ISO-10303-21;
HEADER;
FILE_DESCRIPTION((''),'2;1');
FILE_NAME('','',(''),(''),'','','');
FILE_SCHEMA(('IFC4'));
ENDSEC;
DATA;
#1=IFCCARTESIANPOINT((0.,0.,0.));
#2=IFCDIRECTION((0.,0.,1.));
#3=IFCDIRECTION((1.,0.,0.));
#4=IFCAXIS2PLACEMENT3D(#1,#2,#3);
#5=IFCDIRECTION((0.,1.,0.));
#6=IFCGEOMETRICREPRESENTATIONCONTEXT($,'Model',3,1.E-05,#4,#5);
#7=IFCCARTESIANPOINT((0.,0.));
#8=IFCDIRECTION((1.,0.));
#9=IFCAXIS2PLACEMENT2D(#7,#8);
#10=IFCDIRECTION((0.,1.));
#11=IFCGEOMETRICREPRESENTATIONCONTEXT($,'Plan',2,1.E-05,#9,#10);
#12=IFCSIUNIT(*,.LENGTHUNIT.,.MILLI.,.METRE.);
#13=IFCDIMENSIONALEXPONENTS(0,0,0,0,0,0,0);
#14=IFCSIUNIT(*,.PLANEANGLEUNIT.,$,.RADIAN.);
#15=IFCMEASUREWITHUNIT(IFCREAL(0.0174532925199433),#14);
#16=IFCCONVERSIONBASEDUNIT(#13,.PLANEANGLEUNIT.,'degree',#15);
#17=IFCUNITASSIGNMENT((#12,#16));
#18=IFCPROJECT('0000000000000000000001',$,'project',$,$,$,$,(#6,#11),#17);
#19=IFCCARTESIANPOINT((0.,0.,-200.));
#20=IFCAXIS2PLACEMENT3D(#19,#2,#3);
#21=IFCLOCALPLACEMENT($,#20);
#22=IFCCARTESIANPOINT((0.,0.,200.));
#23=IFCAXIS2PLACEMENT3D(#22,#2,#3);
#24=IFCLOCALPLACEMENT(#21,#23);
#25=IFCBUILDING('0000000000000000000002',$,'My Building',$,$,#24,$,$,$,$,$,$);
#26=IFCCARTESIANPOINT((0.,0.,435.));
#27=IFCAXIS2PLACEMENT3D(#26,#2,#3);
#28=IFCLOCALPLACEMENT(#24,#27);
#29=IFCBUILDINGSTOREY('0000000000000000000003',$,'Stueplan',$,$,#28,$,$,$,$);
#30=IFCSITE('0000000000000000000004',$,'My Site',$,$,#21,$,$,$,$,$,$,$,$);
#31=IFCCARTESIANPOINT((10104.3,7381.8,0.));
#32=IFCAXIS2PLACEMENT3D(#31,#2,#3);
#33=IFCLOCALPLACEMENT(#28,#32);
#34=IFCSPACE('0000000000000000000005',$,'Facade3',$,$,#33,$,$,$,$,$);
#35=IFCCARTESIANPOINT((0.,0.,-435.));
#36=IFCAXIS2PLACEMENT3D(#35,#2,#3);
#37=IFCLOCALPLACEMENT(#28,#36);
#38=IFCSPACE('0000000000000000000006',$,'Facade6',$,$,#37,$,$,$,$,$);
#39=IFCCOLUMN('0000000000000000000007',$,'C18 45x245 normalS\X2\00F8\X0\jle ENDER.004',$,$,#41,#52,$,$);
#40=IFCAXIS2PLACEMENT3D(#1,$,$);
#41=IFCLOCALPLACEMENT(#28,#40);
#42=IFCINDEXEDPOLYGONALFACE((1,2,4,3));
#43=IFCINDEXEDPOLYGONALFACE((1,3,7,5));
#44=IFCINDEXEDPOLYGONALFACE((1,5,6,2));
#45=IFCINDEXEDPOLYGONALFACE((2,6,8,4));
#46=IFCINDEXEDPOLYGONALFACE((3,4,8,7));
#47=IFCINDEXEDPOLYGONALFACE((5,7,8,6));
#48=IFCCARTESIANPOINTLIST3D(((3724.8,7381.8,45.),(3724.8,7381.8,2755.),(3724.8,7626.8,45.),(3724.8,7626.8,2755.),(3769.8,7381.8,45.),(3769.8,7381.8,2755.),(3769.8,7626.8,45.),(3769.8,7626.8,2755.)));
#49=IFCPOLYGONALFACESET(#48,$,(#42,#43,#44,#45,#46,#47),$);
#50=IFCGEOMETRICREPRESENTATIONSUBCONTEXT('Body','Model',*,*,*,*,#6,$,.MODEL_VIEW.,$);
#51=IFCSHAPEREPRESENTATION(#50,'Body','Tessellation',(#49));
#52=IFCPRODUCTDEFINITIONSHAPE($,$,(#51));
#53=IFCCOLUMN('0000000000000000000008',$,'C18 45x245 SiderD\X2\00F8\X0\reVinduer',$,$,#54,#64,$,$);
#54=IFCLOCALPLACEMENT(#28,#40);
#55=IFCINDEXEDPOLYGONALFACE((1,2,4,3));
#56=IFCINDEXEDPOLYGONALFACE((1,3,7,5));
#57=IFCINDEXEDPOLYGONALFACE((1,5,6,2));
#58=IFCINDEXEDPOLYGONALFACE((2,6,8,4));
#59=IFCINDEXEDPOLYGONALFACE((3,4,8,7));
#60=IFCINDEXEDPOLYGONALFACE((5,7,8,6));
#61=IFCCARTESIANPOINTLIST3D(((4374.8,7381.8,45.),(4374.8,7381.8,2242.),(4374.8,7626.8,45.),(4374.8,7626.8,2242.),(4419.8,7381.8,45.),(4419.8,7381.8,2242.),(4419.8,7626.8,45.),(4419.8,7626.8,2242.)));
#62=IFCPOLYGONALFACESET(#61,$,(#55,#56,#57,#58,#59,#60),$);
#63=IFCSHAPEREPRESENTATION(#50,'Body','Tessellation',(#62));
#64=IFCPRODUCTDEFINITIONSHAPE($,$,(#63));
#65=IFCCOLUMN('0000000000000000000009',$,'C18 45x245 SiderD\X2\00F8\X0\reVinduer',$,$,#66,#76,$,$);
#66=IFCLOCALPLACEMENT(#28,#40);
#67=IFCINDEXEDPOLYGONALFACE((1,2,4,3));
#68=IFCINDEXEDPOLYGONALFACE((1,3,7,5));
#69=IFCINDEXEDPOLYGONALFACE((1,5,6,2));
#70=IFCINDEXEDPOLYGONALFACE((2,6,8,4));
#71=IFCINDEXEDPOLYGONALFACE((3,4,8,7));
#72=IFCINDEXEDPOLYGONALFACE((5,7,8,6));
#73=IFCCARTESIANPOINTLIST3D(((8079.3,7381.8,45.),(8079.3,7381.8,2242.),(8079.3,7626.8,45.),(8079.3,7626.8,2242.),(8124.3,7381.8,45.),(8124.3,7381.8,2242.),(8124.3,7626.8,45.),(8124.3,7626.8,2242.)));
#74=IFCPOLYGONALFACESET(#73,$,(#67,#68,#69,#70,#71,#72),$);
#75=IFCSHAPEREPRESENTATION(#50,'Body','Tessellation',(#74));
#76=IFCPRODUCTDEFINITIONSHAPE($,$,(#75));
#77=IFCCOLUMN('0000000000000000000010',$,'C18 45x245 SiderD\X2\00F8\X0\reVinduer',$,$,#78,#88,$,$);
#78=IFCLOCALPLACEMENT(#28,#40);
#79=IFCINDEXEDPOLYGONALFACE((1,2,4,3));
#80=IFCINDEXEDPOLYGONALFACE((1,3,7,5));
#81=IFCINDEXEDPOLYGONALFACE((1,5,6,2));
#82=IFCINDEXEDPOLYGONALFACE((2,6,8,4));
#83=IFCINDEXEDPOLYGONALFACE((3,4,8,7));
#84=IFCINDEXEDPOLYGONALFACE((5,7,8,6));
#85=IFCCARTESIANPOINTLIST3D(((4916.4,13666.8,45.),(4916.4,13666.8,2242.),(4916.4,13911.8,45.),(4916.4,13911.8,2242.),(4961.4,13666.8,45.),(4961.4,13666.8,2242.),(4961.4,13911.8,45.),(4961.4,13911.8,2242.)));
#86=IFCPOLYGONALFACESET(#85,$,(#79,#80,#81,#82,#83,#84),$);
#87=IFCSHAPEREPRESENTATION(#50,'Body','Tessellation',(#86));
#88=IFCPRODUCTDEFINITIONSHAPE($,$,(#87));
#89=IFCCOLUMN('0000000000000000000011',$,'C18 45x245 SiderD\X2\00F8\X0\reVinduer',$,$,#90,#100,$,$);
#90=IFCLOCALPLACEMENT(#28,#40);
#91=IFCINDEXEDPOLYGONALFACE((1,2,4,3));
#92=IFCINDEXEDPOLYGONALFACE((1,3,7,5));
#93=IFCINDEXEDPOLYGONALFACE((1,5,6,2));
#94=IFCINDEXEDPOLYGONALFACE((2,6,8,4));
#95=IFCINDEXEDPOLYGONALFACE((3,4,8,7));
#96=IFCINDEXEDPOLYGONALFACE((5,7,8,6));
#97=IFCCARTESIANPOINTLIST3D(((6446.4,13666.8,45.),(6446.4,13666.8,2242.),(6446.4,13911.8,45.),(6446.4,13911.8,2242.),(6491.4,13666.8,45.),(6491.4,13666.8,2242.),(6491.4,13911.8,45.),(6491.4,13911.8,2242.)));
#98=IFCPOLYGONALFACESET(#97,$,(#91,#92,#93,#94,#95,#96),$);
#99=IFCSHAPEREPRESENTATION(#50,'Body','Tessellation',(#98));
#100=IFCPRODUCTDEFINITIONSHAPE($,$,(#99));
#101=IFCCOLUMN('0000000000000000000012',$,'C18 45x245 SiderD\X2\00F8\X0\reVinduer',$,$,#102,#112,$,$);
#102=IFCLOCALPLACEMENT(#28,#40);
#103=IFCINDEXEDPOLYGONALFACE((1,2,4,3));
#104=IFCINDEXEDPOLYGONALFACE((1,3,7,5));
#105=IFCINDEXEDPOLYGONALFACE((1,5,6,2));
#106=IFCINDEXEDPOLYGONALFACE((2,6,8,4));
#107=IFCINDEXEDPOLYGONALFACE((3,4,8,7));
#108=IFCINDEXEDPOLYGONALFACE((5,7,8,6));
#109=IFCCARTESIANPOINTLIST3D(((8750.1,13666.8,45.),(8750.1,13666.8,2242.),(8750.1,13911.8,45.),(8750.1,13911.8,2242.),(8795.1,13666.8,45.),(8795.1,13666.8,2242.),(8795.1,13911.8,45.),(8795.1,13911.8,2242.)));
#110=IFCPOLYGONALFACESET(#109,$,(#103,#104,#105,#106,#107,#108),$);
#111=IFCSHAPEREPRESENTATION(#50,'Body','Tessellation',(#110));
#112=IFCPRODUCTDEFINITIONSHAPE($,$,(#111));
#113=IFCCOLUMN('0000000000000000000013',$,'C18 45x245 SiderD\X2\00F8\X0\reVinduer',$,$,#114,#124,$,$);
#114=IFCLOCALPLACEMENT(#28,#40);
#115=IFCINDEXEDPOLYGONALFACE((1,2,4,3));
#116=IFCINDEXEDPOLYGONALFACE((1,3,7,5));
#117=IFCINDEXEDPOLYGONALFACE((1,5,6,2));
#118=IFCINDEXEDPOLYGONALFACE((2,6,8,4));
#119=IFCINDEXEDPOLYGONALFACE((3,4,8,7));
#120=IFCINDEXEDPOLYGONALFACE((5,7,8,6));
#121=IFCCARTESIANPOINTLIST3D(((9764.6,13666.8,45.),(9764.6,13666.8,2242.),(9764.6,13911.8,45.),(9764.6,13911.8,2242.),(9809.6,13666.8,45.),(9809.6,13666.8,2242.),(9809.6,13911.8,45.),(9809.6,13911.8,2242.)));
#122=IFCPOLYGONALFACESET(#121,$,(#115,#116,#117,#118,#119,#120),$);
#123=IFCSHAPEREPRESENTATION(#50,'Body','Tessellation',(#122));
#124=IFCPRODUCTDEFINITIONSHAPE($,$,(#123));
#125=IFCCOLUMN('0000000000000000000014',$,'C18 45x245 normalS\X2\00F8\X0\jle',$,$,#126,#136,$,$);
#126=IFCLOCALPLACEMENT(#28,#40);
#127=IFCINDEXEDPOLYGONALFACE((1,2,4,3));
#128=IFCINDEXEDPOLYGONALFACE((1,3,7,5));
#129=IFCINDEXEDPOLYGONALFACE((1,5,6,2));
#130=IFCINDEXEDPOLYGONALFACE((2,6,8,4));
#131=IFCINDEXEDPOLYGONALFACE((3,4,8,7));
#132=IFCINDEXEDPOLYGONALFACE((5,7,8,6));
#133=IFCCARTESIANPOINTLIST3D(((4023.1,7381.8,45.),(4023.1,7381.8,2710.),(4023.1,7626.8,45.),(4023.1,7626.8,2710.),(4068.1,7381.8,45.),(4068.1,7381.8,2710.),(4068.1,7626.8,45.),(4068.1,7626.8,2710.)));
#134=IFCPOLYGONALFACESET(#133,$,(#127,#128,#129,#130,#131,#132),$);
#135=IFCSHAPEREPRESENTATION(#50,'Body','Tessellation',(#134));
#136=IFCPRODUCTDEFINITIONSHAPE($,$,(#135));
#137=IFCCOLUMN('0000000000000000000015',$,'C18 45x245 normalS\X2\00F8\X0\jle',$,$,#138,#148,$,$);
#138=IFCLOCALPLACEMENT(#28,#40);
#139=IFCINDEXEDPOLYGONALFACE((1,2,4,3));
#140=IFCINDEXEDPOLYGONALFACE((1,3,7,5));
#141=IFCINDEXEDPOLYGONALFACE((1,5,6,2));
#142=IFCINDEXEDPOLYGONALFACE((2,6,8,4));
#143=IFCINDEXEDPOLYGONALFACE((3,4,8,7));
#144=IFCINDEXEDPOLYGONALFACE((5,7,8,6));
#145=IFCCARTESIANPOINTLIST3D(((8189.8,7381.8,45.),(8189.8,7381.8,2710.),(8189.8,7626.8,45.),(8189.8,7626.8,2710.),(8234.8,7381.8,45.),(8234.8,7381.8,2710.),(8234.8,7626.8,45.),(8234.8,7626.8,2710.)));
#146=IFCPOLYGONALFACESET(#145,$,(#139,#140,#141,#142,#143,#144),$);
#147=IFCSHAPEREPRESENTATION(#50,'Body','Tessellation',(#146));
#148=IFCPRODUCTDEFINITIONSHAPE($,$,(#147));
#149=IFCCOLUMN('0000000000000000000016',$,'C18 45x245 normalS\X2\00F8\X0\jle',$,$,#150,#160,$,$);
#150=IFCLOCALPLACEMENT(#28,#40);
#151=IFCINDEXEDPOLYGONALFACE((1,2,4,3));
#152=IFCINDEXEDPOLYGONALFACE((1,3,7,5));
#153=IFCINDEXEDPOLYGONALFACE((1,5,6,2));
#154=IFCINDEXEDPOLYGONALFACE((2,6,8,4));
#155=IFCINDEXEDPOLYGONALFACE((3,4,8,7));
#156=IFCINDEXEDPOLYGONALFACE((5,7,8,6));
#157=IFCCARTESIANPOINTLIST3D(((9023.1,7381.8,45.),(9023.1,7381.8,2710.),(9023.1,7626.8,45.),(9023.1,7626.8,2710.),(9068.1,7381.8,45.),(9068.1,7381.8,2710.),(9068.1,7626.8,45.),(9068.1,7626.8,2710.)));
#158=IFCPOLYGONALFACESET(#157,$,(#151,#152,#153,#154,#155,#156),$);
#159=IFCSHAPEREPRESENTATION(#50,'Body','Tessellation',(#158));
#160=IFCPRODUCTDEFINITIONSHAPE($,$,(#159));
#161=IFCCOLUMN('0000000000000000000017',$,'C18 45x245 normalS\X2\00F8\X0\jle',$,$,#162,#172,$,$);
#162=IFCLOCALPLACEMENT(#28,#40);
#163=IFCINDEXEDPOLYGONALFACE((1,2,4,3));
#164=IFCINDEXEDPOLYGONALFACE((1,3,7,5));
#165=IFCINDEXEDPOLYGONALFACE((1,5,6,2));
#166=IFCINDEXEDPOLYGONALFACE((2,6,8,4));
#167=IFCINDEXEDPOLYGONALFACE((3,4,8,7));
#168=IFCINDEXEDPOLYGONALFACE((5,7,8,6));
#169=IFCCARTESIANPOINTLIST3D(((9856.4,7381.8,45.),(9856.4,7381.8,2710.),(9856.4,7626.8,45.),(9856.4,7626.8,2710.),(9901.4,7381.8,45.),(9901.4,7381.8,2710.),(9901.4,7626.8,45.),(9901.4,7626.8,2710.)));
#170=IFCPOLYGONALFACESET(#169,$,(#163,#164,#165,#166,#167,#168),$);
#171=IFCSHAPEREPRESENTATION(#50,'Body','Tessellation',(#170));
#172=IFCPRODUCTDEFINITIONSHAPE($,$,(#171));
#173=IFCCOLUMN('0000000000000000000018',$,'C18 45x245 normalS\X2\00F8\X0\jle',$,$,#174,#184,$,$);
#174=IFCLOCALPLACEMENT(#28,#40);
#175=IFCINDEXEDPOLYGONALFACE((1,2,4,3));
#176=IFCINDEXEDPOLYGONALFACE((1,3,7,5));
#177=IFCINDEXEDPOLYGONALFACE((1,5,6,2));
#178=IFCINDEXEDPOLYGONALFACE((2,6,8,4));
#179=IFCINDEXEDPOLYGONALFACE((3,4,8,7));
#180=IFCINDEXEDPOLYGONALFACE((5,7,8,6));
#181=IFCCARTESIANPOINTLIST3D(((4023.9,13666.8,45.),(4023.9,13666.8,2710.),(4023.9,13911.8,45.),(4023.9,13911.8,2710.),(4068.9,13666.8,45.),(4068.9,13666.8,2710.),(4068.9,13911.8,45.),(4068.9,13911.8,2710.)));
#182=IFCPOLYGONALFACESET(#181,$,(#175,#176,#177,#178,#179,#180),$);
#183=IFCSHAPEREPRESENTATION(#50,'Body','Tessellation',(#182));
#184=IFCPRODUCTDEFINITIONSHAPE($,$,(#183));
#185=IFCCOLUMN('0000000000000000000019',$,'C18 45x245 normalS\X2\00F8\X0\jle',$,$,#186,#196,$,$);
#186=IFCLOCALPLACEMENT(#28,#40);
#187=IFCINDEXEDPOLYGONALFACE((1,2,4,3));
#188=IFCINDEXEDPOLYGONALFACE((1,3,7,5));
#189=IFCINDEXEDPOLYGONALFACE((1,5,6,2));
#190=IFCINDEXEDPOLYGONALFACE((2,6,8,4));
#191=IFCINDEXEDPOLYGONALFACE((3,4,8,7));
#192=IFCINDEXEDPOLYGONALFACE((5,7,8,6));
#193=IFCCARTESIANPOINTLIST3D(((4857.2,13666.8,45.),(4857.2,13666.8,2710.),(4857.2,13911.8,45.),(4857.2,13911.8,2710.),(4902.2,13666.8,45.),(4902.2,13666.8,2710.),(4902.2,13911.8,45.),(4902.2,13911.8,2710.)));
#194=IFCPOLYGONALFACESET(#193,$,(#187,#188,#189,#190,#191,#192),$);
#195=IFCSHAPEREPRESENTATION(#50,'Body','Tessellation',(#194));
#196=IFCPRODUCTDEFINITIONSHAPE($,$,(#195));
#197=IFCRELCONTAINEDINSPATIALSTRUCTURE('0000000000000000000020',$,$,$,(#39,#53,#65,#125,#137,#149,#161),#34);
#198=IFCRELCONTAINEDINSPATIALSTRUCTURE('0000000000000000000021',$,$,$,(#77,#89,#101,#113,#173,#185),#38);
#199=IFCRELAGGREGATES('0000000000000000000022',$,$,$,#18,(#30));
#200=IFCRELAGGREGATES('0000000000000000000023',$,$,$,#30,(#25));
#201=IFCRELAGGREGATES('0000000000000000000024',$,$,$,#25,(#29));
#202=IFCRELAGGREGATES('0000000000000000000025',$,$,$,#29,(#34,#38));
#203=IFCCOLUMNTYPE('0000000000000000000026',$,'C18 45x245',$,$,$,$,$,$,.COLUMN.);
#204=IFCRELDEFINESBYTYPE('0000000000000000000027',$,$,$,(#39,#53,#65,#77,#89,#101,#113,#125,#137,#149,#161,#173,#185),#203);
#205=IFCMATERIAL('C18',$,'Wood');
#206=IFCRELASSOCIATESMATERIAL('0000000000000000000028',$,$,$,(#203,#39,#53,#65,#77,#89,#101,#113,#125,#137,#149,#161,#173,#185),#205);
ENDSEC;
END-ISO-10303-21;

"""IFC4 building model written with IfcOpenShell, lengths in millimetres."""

from ifc_helpers import new_model, entity, si_unit, converted_unit, direction, frame, origin_with_axes, origin_2d_with_axis, place, context, subcontext, project, spatial, rectangle, extrude, material, material_profile, profile_set, profile_usage, type_object, element, save


model = new_model("IFC4")

# Units and contexts
model_context = context("Model", 3, precision=1e-05, world=origin_with_axes(), true_north=direction((0.0, 1.0, 0.0)))
plan_context = context("Plan", 2, precision=1e-05, world=origin_2d_with_axis(), true_north=direction((0.0, 1.0)))
body_context_1 = subcontext(model_context, "Body", "Model", "MODEL_VIEW")
ifc_project = project(units=[si_unit("LENGTHUNIT", "METRE", prefix="MILLI"), converted_unit("PLANEANGLEUNIT", "degree", entity("IfcReal", 0.0174532925199433), si_unit("PLANEANGLEUNIT", "RADIAN"), dimensions=[0, 0, 0, 0, 0, 0, 0])], contexts=[model_context, plan_context])

# Site, building, storey, space
site_placement = place(None, frame((0.0, 0.0, -200.0), z_axis=(0.0, 0.0, 1.0), x_axis=(1.0, 0.0, 0.0)))
site = spatial("IfcSite", under=ifc_project, at=site_placement, Name="My Site")
building_placement = place(site_placement, frame((0.0, 0.0, 200.0), z_axis=(0.0, 0.0, 1.0), x_axis=(1.0, 0.0, 0.0)))
building = spatial("IfcBuilding", under=site, at=building_placement, Name="My Building")
storey_placement = place(building_placement, frame((0.0, 0.0, 435.0), z_axis=(0.0, 0.0, 1.0), x_axis=(1.0, 0.0, 0.0)))
storey = spatial("IfcBuildingStorey", under=building, at=storey_placement, Name="Stueplan")
space_1_placement = place(storey_placement, frame((10104.3, 7381.8, 0.0), z_axis=(0.0, 0.0, 1.0), x_axis=(1.0, 0.0, 0.0)))
space_1 = spatial("IfcSpace", under=storey, at=space_1_placement, Name="Facade3")

# Columns
ifc_material = material(Name="C18", Category="Wood")
ifc_material_profile_1 = material_profile(ifc_material, rectangle(XDim=45.0, YDim=245.0))
ifc_profile_set_1 = profile_set([ifc_material_profile_1], Name="woodStructural")
ifc_profile_usage_1 = profile_usage(ifc_profile_set_1, cardinal=9)
column_type = type_object("IfcColumnType", Name="C18 45x245", PredefinedType="COLUMN", material=ifc_profile_set_1)
column_1_placement = place(space_1_placement, frame((-6379.6, 245.0, 45.0), z_axis=(0.0, 0.0, 1.0), x_axis=(1.0, 0.0, 0.0)))
element("IfcColumn", 1, at=column_1_placement, inside=space_1, type_object=column_type, material=ifc_profile_usage_1, Name="C18 45x245 normalSøjle ENDER.004", context=body_context_1, shape_type="SweptSolid", body=[
    extrude(rectangle(XDim=45.0, YDim=245.0), frame((22.5, -122.5, 0.0), z_axis=(0.0, 0.0, 1.0), x_axis=(1.0, 0.0, 0.0)), (0.0, 0.0, 1.0), 2710.0),
])
ifc_profile_usage_2 = profile_usage(ifc_profile_set_1, cardinal=9)
column_2_placement = place(space_1_placement, frame((-5729.6, 245.0, 45.0), z_axis=(0.0, 0.0, 1.0), x_axis=(1.0, 0.0, 0.0)))
element("IfcColumn", 2, at=column_2_placement, inside=space_1, type_object=column_type, material=ifc_profile_usage_2, Name="C18 45x245 SiderDøreVinduer", context=body_context_1, shape_type="SweptSolid", body=[
    extrude(rectangle(XDim=45.0, YDim=245.0), frame((22.5, -122.5, 0.0), z_axis=(0.0, 0.0, 1.0), x_axis=(1.0, 0.0, 0.0)), (0.0, 0.0, 1.0), 2197.0),
])
ifc_profile_usage_3 = profile_usage(ifc_profile_set_1, cardinal=9)
column_3_placement = place(space_1_placement, frame((-2025.0, 245.0, 45.0), z_axis=(0.0, 0.0, 1.0), x_axis=(1.0, 0.0, 0.0)))
element("IfcColumn", 3, at=column_3_placement, inside=space_1, type_object=column_type, material=ifc_profile_usage_3, Name="C18 45x245 SiderDøreVinduer", context=body_context_1, shape_type="SweptSolid", body=[
    extrude(rectangle(XDim=45.0, YDim=245.0), frame((22.5, -122.5, 0.0), z_axis=(0.0, 0.0, 1.0), x_axis=(1.0, 0.0, 0.0)), (0.0, 0.0, 1.0), 2197.0),
])

# Shared definitions
space_2_placement = place(storey_placement, frame((0.0, 0.0, -435.0), z_axis=(0.0, 0.0, 1.0), x_axis=(1.0, 0.0, 0.0)))
space_2 = spatial("IfcSpace", under=storey, at=space_2_placement, Name="Facade6")

# Columns
ifc_profile_usage_4 = profile_usage(ifc_profile_set_1, cardinal=9)
column_4_placement = place(space_2_placement, frame((4916.4, 13911.8, 480.0), z_axis=(0.0, 0.0, 1.0), x_axis=(1.0, 0.0, 0.0)))
element("IfcColumn", 4, at=column_4_placement, inside=space_2, type_object=column_type, material=ifc_profile_usage_4, Name="C18 45x245 SiderDøreVinduer", context=body_context_1, shape_type="SweptSolid", body=[
    extrude(rectangle(XDim=45.0, YDim=245.0), frame((22.5, -122.5, 0.0), z_axis=(0.0, 0.0, 1.0), x_axis=(1.0, 0.0, 0.0)), (0.0, 0.0, 1.0), 2197.0),
])
ifc_profile_usage_5 = profile_usage(ifc_profile_set_1, cardinal=9)
column_5_placement = place(space_2_placement, frame((6446.4, 13911.8, 480.0), z_axis=(0.0, 0.0, 1.0), x_axis=(1.0, 0.0, 0.0)))
element("IfcColumn", 5, at=column_5_placement, inside=space_2, type_object=column_type, material=ifc_profile_usage_5, Name="C18 45x245 SiderDøreVinduer", context=body_context_1, shape_type="SweptSolid", body=[
    extrude(rectangle(XDim=45.0, YDim=245.0), frame((22.5, -122.5, 0.0), z_axis=(0.0, 0.0, 1.0), x_axis=(1.0, 0.0, 0.0)), (0.0, 0.0, 1.0), 2197.0),
])
ifc_profile_usage_6 = profile_usage(ifc_profile_set_1, cardinal=9)
column_6_placement = place(space_2_placement, frame((8750.1, 13911.8, 480.0), z_axis=(0.0, 0.0, 1.0), x_axis=(1.0, 0.0, 0.0)))
element("IfcColumn", 6, at=column_6_placement, inside=space_2, type_object=column_type, material=ifc_profile_usage_6, Name="C18 45x245 SiderDøreVinduer", context=body_context_1, shape_type="SweptSolid", body=[
    extrude(rectangle(XDim=45.0, YDim=245.0), frame((22.5, -122.5, 0.0), z_axis=(0.0, 0.0, 1.0), x_axis=(1.0, 0.0, 0.0)), (0.0, 0.0, 1.0), 2197.0),
])
ifc_profile_usage_7 = profile_usage(ifc_profile_set_1, cardinal=9)
column_7_placement = place(space_2_placement, frame((9764.6, 13911.8, 480.0), z_axis=(0.0, 0.0, 1.0), x_axis=(1.0, 0.0, 0.0)))
element("IfcColumn", 7, at=column_7_placement, inside=space_2, type_object=column_type, material=ifc_profile_usage_7, Name="C18 45x245 SiderDøreVinduer", context=body_context_1, shape_type="SweptSolid", body=[
    extrude(rectangle(XDim=45.0, YDim=245.0), frame((22.5, -122.5, 0.0), z_axis=(0.0, 0.0, 1.0), x_axis=(1.0, 0.0, 0.0)), (0.0, 0.0, 1.0), 2197.0),
])
ifc_profile_usage_8 = profile_usage(ifc_profile_set_1, cardinal=9)
column_8_placement = place(space_1_placement, frame((-6081.2, 245.0, 45.0), z_axis=(0.0, 0.0, 1.0), x_axis=(1.0, 0.0, 0.0)))
element("IfcColumn", 8, at=column_8_placement, inside=space_1, type_object=column_type, material=ifc_profile_usage_8, Name="C18 45x245 normalSøjle", context=body_context_1, shape_type="SweptSolid", body=[
    extrude(rectangle(XDim=45.0, YDim=245.0), frame((22.5, -122.5, 0.0), z_axis=(0.0, 0.0, 1.0), x_axis=(1.0, 0.0, 0.0)), (0.0, 0.0, 1.0), 2665.0),
])
ifc_profile_usage_9 = profile_usage(ifc_profile_set_1, cardinal=9)
column_9_placement = place(space_1_placement, frame((-1914.6, 245.0, 45.0), z_axis=(0.0, 0.0, 1.0), x_axis=(1.0, 0.0, 0.0)))
element("IfcColumn", 9, at=column_9_placement, inside=space_1, type_object=column_type, material=ifc_profile_usage_9, Name="C18 45x245 normalSøjle", context=body_context_1, shape_type="SweptSolid", body=[
    extrude(rectangle(XDim=45.0, YDim=245.0), frame((22.5, -122.5, 0.0), z_axis=(0.0, 0.0, 1.0), x_axis=(1.0, 0.0, 0.0)), (0.0, 0.0, 1.0), 2665.0),
])
ifc_profile_usage_10 = profile_usage(ifc_profile_set_1, cardinal=9)
column_10_placement = place(space_1_placement, frame((-1081.2, 245.0, 45.0), z_axis=(0.0, 0.0, 1.0), x_axis=(1.0, 0.0, 0.0)))
element("IfcColumn", 10, at=column_10_placement, inside=space_1, type_object=column_type, material=ifc_profile_usage_10, Name="C18 45x245 normalSøjle", context=body_context_1, shape_type="SweptSolid", body=[
    extrude(rectangle(XDim=45.0, YDim=245.0), frame((22.5, -122.5, 0.0), z_axis=(0.0, 0.0, 1.0), x_axis=(1.0, 0.0, 0.0)), (0.0, 0.0, 1.0), 2665.0),
])
ifc_profile_usage_11 = profile_usage(ifc_profile_set_1, cardinal=9)
column_11_placement = place(space_1_placement, frame((-247.9, 245.0, 45.0), z_axis=(0.0, 0.0, 1.0), x_axis=(1.0, 0.0, 0.0)))
element("IfcColumn", 11, at=column_11_placement, inside=space_1, type_object=column_type, material=ifc_profile_usage_11, Name="C18 45x245 normalSøjle", context=body_context_1, shape_type="SweptSolid", body=[
    extrude(rectangle(XDim=45.0, YDim=245.0), frame((22.5, -122.5, 0.0), z_axis=(0.0, 0.0, 1.0), x_axis=(1.0, 0.0, 0.0)), (0.0, 0.0, 1.0), 2665.0),
])
ifc_profile_usage_12 = profile_usage(ifc_profile_set_1, cardinal=9)
column_12_placement = place(space_2_placement, frame((4023.9, 13911.8, 480.0), z_axis=(0.0, 0.0, 1.0), x_axis=(1.0, 0.0, 0.0)))
element("IfcColumn", 12, at=column_12_placement, inside=space_2, type_object=column_type, material=ifc_profile_usage_12, Name="C18 45x245 normalSøjle", context=body_context_1, shape_type="SweptSolid", body=[
    extrude(rectangle(XDim=45.0, YDim=245.0), frame((22.5, -122.5, 0.0), z_axis=(0.0, 0.0, 1.0), x_axis=(1.0, 0.0, 0.0)), (0.0, 0.0, 1.0), 2665.0),
])
ifc_profile_usage_13 = profile_usage(ifc_profile_set_1, cardinal=9)
column_13_placement = place(space_2_placement, frame((4857.2, 13911.8, 480.0), z_axis=(0.0, 0.0, 1.0), x_axis=(1.0, 0.0, 0.0)))
element("IfcColumn", 13, at=column_13_placement, inside=space_2, type_object=column_type, material=ifc_profile_usage_13, Name="C18 45x245 normalSøjle", context=body_context_1, shape_type="SweptSolid", body=[
    extrude(rectangle(XDim=45.0, YDim=245.0), frame((22.5, -122.5, 0.0), z_axis=(0.0, 0.0, 1.0), x_axis=(1.0, 0.0, 0.0)), (0.0, 0.0, 1.0), 2665.0),
])

save(model, "model.ifc")
